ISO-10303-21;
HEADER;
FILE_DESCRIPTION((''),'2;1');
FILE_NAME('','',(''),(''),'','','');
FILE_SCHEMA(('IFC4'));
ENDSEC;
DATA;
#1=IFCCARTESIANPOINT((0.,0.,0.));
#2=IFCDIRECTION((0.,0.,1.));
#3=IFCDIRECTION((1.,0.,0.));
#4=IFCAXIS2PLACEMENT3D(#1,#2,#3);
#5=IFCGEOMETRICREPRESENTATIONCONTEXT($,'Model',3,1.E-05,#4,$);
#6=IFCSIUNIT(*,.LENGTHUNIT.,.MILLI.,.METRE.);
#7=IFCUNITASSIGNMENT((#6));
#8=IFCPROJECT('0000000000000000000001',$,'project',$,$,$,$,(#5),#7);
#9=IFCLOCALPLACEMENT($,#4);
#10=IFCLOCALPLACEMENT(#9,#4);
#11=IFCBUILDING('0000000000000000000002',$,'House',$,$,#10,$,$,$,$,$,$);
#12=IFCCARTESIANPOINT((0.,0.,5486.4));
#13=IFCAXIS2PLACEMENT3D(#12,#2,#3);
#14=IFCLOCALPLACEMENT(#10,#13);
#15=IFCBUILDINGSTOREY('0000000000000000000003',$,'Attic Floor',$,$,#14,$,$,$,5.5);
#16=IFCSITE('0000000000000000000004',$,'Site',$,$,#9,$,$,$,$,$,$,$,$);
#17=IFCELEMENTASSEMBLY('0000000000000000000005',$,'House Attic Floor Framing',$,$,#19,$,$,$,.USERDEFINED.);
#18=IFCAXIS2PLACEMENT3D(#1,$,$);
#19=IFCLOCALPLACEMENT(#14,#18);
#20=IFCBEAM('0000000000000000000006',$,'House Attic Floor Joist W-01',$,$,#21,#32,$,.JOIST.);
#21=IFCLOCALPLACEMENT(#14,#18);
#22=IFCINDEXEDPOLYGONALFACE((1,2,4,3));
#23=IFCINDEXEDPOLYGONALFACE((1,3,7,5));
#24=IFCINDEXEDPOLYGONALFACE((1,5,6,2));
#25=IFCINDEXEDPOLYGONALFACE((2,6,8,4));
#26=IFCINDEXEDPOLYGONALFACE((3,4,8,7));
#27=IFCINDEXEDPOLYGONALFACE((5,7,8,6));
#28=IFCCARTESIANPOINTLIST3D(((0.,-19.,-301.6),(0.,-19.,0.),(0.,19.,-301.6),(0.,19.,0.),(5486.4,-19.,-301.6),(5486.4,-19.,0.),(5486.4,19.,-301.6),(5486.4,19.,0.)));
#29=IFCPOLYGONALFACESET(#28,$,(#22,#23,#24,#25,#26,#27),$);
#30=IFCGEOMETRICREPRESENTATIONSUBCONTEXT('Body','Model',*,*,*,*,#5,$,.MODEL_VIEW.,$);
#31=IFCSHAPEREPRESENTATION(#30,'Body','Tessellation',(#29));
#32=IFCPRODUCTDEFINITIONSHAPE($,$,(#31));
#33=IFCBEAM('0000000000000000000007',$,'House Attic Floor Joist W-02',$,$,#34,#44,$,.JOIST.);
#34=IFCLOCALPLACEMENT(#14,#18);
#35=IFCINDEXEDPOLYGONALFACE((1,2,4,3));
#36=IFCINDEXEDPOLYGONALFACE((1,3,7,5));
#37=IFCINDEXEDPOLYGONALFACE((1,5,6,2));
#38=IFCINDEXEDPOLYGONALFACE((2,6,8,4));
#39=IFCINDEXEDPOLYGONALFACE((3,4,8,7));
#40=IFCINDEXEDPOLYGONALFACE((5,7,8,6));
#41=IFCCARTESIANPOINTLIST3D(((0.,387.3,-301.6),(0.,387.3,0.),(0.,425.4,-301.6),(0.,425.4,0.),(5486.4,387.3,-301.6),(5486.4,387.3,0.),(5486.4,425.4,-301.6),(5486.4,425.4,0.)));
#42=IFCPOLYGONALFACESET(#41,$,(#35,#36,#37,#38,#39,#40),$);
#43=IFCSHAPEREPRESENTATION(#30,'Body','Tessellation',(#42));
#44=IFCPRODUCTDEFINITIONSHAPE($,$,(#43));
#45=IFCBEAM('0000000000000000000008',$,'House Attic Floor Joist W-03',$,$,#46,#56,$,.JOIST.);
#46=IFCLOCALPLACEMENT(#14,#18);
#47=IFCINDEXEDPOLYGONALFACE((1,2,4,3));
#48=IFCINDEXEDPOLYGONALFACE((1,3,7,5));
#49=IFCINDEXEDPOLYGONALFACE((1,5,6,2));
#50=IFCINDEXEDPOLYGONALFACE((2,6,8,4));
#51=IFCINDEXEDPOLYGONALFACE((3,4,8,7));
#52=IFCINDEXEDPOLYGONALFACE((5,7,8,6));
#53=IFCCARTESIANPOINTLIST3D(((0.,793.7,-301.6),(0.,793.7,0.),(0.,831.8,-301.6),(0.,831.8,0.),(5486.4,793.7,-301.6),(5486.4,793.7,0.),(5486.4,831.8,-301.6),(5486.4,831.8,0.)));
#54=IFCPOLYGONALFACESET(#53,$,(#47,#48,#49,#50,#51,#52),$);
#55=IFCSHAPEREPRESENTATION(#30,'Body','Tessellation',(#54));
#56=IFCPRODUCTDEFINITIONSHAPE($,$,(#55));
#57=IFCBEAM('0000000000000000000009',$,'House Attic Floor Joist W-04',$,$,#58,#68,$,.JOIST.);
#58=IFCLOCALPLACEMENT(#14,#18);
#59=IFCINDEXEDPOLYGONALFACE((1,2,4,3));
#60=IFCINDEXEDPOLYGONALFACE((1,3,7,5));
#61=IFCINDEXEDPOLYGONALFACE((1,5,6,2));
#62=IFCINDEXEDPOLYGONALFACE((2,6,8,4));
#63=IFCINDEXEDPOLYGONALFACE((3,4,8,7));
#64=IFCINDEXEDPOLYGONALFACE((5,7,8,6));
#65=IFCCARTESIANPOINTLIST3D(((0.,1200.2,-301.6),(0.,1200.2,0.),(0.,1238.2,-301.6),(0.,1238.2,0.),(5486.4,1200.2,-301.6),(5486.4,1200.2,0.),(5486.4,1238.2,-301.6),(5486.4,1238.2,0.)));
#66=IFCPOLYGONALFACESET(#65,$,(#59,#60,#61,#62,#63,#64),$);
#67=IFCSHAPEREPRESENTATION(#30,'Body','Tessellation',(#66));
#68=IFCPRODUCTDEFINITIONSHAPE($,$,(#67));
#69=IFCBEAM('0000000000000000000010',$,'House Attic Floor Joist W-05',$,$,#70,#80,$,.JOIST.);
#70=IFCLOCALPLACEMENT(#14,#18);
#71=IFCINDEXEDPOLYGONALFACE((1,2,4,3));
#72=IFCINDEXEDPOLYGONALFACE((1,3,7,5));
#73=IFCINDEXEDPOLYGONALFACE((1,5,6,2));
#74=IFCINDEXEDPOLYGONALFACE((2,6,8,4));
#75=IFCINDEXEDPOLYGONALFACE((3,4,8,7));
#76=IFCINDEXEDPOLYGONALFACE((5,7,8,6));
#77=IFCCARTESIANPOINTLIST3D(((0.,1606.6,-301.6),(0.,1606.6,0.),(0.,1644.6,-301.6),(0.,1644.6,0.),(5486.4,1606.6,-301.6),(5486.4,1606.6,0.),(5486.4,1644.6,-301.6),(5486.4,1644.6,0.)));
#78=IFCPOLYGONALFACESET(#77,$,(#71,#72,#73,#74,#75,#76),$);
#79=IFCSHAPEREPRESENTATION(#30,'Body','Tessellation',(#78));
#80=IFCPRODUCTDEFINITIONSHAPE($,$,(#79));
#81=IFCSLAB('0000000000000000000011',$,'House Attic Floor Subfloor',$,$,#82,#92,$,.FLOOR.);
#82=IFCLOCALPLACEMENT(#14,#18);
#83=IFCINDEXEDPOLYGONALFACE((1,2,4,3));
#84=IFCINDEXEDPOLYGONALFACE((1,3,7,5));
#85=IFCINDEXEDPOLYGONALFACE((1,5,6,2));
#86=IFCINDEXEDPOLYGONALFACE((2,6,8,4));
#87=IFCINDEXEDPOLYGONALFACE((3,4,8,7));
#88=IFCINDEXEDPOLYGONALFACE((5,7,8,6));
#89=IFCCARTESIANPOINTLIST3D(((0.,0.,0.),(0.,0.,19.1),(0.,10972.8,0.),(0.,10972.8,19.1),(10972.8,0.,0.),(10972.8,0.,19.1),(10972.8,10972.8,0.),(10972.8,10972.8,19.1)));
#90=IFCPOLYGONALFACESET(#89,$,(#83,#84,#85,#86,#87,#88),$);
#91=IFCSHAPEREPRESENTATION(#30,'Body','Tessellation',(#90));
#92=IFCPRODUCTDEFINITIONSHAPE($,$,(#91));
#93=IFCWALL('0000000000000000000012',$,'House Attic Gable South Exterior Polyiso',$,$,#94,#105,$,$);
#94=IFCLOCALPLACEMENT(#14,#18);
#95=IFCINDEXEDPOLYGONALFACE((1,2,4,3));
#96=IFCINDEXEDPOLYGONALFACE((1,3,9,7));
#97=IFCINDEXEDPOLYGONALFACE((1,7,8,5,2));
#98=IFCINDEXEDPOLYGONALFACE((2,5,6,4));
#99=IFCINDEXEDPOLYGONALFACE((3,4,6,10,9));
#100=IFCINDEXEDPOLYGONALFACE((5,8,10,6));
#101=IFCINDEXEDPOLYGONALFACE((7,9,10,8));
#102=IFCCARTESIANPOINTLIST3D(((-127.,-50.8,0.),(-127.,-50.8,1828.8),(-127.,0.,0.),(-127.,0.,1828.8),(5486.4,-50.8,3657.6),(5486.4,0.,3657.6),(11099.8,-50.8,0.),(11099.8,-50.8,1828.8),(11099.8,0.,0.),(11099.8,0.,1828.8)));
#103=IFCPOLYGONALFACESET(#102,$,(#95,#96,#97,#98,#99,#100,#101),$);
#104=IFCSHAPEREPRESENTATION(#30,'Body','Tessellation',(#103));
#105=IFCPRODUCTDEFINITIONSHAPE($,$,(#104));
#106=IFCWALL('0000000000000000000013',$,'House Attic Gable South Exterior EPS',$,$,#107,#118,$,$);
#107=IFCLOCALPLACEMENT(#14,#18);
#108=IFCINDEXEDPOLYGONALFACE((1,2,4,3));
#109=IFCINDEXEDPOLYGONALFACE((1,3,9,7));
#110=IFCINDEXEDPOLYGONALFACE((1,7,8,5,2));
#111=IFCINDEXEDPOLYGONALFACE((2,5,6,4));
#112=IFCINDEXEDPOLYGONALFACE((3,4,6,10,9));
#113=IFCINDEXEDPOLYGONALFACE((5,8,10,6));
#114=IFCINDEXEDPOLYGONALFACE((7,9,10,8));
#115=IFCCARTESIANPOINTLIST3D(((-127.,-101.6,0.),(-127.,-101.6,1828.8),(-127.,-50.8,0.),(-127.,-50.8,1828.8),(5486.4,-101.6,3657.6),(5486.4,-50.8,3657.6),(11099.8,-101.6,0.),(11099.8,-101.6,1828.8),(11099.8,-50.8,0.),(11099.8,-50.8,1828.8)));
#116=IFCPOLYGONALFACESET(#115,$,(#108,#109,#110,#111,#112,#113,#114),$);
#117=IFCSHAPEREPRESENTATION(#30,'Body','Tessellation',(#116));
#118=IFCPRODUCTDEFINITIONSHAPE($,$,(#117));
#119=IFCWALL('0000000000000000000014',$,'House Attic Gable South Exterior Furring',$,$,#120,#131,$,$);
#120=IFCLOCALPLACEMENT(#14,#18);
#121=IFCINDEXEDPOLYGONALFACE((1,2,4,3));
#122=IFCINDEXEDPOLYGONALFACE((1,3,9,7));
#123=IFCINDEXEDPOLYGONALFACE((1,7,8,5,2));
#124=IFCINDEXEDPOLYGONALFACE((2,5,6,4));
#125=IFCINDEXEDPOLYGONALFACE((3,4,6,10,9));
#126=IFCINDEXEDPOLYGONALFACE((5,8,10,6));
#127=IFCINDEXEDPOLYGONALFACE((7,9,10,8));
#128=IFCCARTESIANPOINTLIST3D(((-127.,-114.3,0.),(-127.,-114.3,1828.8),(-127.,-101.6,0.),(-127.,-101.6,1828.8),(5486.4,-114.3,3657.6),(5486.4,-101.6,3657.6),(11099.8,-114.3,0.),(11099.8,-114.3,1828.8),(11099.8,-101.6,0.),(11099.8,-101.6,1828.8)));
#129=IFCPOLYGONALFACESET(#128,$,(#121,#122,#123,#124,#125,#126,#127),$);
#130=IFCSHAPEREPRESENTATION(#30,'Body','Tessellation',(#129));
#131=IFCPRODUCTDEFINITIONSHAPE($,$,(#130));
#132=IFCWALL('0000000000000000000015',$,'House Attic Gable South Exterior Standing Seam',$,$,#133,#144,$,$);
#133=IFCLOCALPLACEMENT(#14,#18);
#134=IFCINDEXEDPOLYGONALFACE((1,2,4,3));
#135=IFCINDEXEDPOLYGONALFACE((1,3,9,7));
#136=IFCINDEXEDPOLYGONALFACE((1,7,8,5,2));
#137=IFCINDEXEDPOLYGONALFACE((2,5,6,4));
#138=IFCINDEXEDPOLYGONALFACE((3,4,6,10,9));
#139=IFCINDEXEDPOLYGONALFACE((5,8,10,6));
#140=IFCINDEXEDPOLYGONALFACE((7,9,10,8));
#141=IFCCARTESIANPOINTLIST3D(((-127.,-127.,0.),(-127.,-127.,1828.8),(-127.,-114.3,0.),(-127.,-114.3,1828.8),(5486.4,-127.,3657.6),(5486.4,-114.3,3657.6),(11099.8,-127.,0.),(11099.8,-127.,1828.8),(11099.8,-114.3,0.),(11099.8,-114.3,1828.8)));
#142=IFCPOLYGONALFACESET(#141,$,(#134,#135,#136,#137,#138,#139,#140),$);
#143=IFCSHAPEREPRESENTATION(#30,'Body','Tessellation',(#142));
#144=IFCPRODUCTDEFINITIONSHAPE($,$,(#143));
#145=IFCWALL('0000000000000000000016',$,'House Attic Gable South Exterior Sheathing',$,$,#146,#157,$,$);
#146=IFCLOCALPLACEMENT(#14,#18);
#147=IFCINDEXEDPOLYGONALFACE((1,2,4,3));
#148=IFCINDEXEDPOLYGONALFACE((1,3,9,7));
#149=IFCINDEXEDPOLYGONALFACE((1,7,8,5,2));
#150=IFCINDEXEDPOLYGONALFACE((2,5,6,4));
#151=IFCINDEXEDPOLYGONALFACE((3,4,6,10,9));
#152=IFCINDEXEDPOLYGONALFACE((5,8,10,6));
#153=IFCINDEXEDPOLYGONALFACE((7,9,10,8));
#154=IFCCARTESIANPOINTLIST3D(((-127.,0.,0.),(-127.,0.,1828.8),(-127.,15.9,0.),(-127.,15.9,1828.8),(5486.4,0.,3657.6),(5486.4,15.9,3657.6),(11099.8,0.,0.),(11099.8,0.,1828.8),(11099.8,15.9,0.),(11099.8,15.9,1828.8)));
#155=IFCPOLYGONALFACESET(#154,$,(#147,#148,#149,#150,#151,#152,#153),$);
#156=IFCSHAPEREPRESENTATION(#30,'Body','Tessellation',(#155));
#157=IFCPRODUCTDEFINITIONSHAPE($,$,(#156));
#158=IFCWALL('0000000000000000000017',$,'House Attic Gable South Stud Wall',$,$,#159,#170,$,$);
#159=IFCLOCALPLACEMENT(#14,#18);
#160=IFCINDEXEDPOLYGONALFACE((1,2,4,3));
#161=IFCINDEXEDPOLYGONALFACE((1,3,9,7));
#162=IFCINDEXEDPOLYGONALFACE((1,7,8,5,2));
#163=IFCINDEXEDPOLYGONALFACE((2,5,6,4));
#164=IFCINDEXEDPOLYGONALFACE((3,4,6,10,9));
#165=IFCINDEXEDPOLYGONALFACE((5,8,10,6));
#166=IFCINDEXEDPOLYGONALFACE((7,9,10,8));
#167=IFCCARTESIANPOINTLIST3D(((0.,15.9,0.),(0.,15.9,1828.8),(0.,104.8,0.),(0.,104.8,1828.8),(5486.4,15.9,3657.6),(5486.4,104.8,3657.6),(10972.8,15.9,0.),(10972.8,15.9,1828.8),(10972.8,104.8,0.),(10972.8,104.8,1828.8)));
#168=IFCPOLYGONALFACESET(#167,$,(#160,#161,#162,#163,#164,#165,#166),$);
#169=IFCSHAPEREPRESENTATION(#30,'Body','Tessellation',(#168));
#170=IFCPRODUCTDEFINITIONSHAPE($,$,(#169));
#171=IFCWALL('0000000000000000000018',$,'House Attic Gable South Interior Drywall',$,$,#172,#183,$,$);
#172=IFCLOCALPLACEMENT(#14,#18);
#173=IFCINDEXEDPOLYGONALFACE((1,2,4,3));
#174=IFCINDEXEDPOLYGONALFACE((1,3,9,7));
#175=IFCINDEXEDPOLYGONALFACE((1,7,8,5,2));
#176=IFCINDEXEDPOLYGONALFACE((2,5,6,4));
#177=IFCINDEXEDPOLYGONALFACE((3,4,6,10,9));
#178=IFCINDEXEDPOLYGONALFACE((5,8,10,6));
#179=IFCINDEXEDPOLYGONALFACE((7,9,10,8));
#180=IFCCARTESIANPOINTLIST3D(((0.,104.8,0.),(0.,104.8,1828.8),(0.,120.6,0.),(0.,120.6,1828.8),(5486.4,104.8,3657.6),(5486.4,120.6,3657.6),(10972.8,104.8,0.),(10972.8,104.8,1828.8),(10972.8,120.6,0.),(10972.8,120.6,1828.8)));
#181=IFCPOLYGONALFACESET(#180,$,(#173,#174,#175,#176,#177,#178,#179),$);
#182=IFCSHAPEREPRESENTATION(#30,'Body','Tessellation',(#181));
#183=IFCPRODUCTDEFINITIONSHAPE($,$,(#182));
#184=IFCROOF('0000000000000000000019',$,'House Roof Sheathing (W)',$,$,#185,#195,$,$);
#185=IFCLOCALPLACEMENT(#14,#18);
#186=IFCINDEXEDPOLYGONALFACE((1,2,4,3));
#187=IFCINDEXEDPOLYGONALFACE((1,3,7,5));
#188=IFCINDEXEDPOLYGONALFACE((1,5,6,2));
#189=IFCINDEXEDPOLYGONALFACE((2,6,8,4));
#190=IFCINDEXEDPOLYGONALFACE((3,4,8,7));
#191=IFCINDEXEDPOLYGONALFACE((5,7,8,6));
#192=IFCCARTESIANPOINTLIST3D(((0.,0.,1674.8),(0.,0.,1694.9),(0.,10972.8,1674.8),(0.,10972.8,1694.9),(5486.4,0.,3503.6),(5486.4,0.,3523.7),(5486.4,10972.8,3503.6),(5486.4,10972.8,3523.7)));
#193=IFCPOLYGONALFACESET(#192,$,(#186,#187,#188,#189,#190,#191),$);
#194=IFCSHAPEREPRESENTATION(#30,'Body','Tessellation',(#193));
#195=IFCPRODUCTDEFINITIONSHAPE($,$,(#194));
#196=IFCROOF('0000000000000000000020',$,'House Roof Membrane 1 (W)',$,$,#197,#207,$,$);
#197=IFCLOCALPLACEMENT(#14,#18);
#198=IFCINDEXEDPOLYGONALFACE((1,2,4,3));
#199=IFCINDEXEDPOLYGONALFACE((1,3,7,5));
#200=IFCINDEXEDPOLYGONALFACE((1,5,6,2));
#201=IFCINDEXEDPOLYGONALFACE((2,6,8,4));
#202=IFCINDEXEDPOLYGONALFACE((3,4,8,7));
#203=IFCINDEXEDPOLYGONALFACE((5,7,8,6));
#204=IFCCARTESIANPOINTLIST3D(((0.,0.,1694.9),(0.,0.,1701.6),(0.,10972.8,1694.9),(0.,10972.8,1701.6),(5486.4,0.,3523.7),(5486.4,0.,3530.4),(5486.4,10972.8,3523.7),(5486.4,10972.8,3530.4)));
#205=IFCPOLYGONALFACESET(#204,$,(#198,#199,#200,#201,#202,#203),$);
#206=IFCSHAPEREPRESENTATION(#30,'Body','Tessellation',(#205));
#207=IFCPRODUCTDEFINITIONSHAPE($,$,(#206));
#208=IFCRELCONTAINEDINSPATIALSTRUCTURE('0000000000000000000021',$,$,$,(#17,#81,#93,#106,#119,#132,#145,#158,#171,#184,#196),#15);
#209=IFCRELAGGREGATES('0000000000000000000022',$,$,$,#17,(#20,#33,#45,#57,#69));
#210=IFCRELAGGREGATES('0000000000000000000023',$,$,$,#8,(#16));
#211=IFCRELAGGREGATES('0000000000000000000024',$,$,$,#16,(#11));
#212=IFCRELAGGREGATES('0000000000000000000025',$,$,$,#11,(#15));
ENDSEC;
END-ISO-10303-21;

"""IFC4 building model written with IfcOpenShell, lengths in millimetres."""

from ifc_helpers import new_model, si_unit, frame, origin_with_axes, origin_2d, place, context, subcontext, project, spatial, indexed_curve, rectangle, outline, extrude, element, aggregate, save


model = new_model("IFC4")

# Units and contexts
model_context = context("Model", 3, precision=1e-05, world=origin_with_axes())
body_context = subcontext(model_context, "Body", "Model", "MODEL_VIEW")
ifc_project = project(units=[si_unit("LENGTHUNIT", "METRE", prefix="MILLI")], contexts=[model_context])

# Site, building, storey
site_placement = place(None, origin_with_axes())
site = spatial("IfcSite", under=ifc_project, at=site_placement, Name="Site")
building_placement = place(site_placement, origin_with_axes())
building = spatial("IfcBuilding", under=site, at=building_placement, Name="House")
storey_placement = place(building_placement, frame((0.0, 0.0, 5486.4), z_axis=(0.0, 0.0, 1.0), x_axis=(1.0, 0.0, 0.0)))
storey = spatial("IfcBuildingStorey", under=building, at=storey_placement, Name="Attic Floor", Elevation=5.5)

# Element assembly, beams
assembly_placement = place(storey_placement, frame((0.0, 0.0, -5486.4), z_axis=(0.0, 0.0, 1.0), x_axis=(1.0, 0.0, 0.0)))
assembly = element("IfcElementAssembly", 1, at=assembly_placement, inside=storey, Name="House Attic Floor Framing", PredefinedType="USERDEFINED")
beam_1_placement = place(assembly_placement, frame((0.0, 0.0, 5335.6), z_axis=(1.0, 0.0, 0.0), x_axis=(0.0, 1.0, 0.0)))
beam_1 = element("IfcBeam", 2, at=beam_1_placement, Name="House Attic Floor Joist W-01", PredefinedType="JOIST", context=body_context, shape_type="SweptSolid", body=[
    extrude(rectangle(XDim=38.1, YDim=301.6, at=origin_2d()), origin_with_axes(), (0.0, 0.0, 1.0), 5486.4),
])
beam_2_placement = place(assembly_placement, frame((0.0, 406.4, 5335.6), z_axis=(1.0, 0.0, 0.0), x_axis=(0.0, 1.0, 0.0)))
beam_2 = element("IfcBeam", 3, at=beam_2_placement, Name="House Attic Floor Joist W-02", PredefinedType="JOIST", context=body_context, shape_type="SweptSolid", body=[
    extrude(rectangle(XDim=38.1, YDim=301.6, at=origin_2d()), origin_with_axes(), (0.0, 0.0, 1.0), 5486.4),
])
beam_3_placement = place(assembly_placement, frame((0.0, 812.8, 5335.6), z_axis=(1.0, 0.0, 0.0), x_axis=(0.0, 1.0, 0.0)))
beam_3 = element("IfcBeam", 4, at=beam_3_placement, Name="House Attic Floor Joist W-03", PredefinedType="JOIST", context=body_context, shape_type="SweptSolid", body=[
    extrude(rectangle(XDim=38.1, YDim=301.6, at=origin_2d()), origin_with_axes(), (0.0, 0.0, 1.0), 5486.4),
])
beam_4_placement = place(assembly_placement, frame((0.0, 1219.2, 5335.6), z_axis=(1.0, 0.0, 0.0), x_axis=(0.0, 1.0, 0.0)))
beam_4 = element("IfcBeam", 5, at=beam_4_placement, Name="House Attic Floor Joist W-04", PredefinedType="JOIST", context=body_context, shape_type="SweptSolid", body=[
    extrude(rectangle(XDim=38.1, YDim=301.6, at=origin_2d()), origin_with_axes(), (0.0, 0.0, 1.0), 5486.4),
])
beam_5_placement = place(assembly_placement, frame((0.0, 1625.6, 5335.6), z_axis=(1.0, 0.0, 0.0), x_axis=(0.0, 1.0, 0.0)))
beam_5 = element("IfcBeam", 6, at=beam_5_placement, Name="House Attic Floor Joist W-05", PredefinedType="JOIST", context=body_context, shape_type="SweptSolid", body=[
    extrude(rectangle(XDim=38.1, YDim=301.6, at=origin_2d()), origin_with_axes(), (0.0, 0.0, 1.0), 5486.4),
])
aggregate(assembly, [beam_1, beam_2, beam_3, beam_4, beam_5])

# Slab
slab_placement = place(storey_placement, origin_with_axes())
element("IfcSlab", 7, at=slab_placement, inside=storey, Name="House Attic Floor Subfloor", PredefinedType="FLOOR", context=body_context, shape_type="SweptSolid", body=[
    extrude(outline(indexed_curve([(0.0, 0.0), (10972.8, 0.0), (10972.8, 10972.8), (0.0, 10972.8), (0.0, 0.0)])), None, (0.0, 0.0, 1.0), 19.1),
])

# Walls
for number, where, z_axis, x_axis, name in (
    (8, (0.0, -50.8, 0.0), (0.0, 1.0, 0.0), (1.0, 0.0, 0.0), "House Attic Gable South Exterior Polyiso"),
    (9, (0.0, -101.6, 0.0), (0.0, 1.0, 0.0), (1.0, 0.0, 0.0), "House Attic Gable South Exterior EPS"),
):
    element("IfcWall", number, at=place(storey_placement, frame(where, z_axis=z_axis, x_axis=x_axis)), inside=storey, Name=name, context=body_context, shape_type="SweptSolid", body=[
        extrude(outline(indexed_curve([(-127.0, 0.0), (11099.8, 0.0), (11099.8, -1828.8), (5486.4, -3657.6), (-127.0, -1828.8), (-127.0, 0.0)])), origin_with_axes(), (0.0, 0.0, 1.0), 50.8),
    ])
for number, where, z_axis, x_axis, name in (
    (10, (0.0, -114.3, 0.0), (0.0, 1.0, 0.0), (1.0, 0.0, 0.0), "House Attic Gable South Exterior Furring"),
    (11, (0.0, -127.0, 0.0), (0.0, 1.0, 0.0), (1.0, 0.0, 0.0), "House Attic Gable South Exterior Standing Seam"),
):
    element("IfcWall", number, at=place(storey_placement, frame(where, z_axis=z_axis, x_axis=x_axis)), inside=storey, Name=name, context=body_context, shape_type="SweptSolid", body=[
        extrude(outline(indexed_curve([(-127.0, 0.0), (11099.8, 0.0), (11099.8, -1828.8), (5486.4, -3657.6), (-127.0, -1828.8), (-127.0, 0.0)])), origin_with_axes(), (0.0, 0.0, 1.0), 12.7),
    ])
wall_1_placement = place(storey_placement, frame((0.0, 0.0, 0.0), z_axis=(0.0, 1.0, 0.0), x_axis=(1.0, 0.0, 0.0)))
element("IfcWall", 12, at=wall_1_placement, inside=storey, Name="House Attic Gable South Exterior Sheathing", context=body_context, shape_type="SweptSolid", body=[
    extrude(outline(indexed_curve([(-127.0, 0.0), (11099.8, 0.0), (11099.8, -1828.8), (5486.4, -3657.6), (-127.0, -1828.8), (-127.0, 0.0)])), origin_with_axes(), (0.0, 0.0, 1.0), 15.9),
])
wall_2_placement = place(storey_placement, frame((0.0, 15.9, 0.0), z_axis=(0.0, 1.0, 0.0), x_axis=(1.0, 0.0, 0.0)))
element("IfcWall", 13, at=wall_2_placement, inside=storey, Name="House Attic Gable South Stud Wall", context=body_context, shape_type="SweptSolid", body=[
    extrude(outline(indexed_curve([(0.0, 0.0), (10972.8, 0.0), (10972.8, -1828.8), (5486.4, -3657.6), (0.0, -1828.8), (0.0, 0.0)])), origin_with_axes(), (0.0, 0.0, 1.0), 88.9),
])
wall_3_placement = place(storey_placement, frame((0.0, 104.8, 0.0), z_axis=(0.0, 1.0, 0.0), x_axis=(1.0, 0.0, 0.0)))
element("IfcWall", 14, at=wall_3_placement, inside=storey, Name="House Attic Gable South Interior Drywall", context=body_context, shape_type="SweptSolid", body=[
    extrude(outline(indexed_curve([(0.0, 0.0), (10972.8, 0.0), (10972.8, -1828.8), (5486.4, -3657.6), (0.0, -1828.8), (0.0, 0.0)])), origin_with_axes(), (0.0, 0.0, 1.0), 15.9),
])

# Roofs
roof_1_placement = place(storey_placement, frame((0.0, 0.0, 0.0), z_axis=(0.0, 1.0, 0.0), x_axis=(1.0, 0.0, 0.0)))
element("IfcRoof", 15, at=roof_1_placement, inside=storey, Name="House Roof Sheathing (W)", context=body_context, shape_type="SweptSolid", body=[
    extrude(outline(indexed_curve([(0.0, -1694.9), (5486.4, -3523.7), (5486.4, -3503.6), (0.0, -1674.8), (0.0, -1694.9)])), origin_with_axes(), (0.0, 0.0, 1.0), 10972.8),
])
roof_2_placement = place(storey_placement, frame((0.0, 0.0, 0.0), z_axis=(0.0, 1.0, 0.0), x_axis=(1.0, 0.0, 0.0)))
element("IfcRoof", 16, at=roof_2_placement, inside=storey, Name="House Roof Membrane 1 (W)", context=body_context, shape_type="SweptSolid", body=[
    extrude(outline(indexed_curve([(0.0, -1701.6), (5486.4, -3530.4), (5486.4, -3523.7), (0.0, -1694.9), (0.0, -1701.6)])), origin_with_axes(), (0.0, 0.0, 1.0), 10972.8),
])

save(model, "model.ifc")
